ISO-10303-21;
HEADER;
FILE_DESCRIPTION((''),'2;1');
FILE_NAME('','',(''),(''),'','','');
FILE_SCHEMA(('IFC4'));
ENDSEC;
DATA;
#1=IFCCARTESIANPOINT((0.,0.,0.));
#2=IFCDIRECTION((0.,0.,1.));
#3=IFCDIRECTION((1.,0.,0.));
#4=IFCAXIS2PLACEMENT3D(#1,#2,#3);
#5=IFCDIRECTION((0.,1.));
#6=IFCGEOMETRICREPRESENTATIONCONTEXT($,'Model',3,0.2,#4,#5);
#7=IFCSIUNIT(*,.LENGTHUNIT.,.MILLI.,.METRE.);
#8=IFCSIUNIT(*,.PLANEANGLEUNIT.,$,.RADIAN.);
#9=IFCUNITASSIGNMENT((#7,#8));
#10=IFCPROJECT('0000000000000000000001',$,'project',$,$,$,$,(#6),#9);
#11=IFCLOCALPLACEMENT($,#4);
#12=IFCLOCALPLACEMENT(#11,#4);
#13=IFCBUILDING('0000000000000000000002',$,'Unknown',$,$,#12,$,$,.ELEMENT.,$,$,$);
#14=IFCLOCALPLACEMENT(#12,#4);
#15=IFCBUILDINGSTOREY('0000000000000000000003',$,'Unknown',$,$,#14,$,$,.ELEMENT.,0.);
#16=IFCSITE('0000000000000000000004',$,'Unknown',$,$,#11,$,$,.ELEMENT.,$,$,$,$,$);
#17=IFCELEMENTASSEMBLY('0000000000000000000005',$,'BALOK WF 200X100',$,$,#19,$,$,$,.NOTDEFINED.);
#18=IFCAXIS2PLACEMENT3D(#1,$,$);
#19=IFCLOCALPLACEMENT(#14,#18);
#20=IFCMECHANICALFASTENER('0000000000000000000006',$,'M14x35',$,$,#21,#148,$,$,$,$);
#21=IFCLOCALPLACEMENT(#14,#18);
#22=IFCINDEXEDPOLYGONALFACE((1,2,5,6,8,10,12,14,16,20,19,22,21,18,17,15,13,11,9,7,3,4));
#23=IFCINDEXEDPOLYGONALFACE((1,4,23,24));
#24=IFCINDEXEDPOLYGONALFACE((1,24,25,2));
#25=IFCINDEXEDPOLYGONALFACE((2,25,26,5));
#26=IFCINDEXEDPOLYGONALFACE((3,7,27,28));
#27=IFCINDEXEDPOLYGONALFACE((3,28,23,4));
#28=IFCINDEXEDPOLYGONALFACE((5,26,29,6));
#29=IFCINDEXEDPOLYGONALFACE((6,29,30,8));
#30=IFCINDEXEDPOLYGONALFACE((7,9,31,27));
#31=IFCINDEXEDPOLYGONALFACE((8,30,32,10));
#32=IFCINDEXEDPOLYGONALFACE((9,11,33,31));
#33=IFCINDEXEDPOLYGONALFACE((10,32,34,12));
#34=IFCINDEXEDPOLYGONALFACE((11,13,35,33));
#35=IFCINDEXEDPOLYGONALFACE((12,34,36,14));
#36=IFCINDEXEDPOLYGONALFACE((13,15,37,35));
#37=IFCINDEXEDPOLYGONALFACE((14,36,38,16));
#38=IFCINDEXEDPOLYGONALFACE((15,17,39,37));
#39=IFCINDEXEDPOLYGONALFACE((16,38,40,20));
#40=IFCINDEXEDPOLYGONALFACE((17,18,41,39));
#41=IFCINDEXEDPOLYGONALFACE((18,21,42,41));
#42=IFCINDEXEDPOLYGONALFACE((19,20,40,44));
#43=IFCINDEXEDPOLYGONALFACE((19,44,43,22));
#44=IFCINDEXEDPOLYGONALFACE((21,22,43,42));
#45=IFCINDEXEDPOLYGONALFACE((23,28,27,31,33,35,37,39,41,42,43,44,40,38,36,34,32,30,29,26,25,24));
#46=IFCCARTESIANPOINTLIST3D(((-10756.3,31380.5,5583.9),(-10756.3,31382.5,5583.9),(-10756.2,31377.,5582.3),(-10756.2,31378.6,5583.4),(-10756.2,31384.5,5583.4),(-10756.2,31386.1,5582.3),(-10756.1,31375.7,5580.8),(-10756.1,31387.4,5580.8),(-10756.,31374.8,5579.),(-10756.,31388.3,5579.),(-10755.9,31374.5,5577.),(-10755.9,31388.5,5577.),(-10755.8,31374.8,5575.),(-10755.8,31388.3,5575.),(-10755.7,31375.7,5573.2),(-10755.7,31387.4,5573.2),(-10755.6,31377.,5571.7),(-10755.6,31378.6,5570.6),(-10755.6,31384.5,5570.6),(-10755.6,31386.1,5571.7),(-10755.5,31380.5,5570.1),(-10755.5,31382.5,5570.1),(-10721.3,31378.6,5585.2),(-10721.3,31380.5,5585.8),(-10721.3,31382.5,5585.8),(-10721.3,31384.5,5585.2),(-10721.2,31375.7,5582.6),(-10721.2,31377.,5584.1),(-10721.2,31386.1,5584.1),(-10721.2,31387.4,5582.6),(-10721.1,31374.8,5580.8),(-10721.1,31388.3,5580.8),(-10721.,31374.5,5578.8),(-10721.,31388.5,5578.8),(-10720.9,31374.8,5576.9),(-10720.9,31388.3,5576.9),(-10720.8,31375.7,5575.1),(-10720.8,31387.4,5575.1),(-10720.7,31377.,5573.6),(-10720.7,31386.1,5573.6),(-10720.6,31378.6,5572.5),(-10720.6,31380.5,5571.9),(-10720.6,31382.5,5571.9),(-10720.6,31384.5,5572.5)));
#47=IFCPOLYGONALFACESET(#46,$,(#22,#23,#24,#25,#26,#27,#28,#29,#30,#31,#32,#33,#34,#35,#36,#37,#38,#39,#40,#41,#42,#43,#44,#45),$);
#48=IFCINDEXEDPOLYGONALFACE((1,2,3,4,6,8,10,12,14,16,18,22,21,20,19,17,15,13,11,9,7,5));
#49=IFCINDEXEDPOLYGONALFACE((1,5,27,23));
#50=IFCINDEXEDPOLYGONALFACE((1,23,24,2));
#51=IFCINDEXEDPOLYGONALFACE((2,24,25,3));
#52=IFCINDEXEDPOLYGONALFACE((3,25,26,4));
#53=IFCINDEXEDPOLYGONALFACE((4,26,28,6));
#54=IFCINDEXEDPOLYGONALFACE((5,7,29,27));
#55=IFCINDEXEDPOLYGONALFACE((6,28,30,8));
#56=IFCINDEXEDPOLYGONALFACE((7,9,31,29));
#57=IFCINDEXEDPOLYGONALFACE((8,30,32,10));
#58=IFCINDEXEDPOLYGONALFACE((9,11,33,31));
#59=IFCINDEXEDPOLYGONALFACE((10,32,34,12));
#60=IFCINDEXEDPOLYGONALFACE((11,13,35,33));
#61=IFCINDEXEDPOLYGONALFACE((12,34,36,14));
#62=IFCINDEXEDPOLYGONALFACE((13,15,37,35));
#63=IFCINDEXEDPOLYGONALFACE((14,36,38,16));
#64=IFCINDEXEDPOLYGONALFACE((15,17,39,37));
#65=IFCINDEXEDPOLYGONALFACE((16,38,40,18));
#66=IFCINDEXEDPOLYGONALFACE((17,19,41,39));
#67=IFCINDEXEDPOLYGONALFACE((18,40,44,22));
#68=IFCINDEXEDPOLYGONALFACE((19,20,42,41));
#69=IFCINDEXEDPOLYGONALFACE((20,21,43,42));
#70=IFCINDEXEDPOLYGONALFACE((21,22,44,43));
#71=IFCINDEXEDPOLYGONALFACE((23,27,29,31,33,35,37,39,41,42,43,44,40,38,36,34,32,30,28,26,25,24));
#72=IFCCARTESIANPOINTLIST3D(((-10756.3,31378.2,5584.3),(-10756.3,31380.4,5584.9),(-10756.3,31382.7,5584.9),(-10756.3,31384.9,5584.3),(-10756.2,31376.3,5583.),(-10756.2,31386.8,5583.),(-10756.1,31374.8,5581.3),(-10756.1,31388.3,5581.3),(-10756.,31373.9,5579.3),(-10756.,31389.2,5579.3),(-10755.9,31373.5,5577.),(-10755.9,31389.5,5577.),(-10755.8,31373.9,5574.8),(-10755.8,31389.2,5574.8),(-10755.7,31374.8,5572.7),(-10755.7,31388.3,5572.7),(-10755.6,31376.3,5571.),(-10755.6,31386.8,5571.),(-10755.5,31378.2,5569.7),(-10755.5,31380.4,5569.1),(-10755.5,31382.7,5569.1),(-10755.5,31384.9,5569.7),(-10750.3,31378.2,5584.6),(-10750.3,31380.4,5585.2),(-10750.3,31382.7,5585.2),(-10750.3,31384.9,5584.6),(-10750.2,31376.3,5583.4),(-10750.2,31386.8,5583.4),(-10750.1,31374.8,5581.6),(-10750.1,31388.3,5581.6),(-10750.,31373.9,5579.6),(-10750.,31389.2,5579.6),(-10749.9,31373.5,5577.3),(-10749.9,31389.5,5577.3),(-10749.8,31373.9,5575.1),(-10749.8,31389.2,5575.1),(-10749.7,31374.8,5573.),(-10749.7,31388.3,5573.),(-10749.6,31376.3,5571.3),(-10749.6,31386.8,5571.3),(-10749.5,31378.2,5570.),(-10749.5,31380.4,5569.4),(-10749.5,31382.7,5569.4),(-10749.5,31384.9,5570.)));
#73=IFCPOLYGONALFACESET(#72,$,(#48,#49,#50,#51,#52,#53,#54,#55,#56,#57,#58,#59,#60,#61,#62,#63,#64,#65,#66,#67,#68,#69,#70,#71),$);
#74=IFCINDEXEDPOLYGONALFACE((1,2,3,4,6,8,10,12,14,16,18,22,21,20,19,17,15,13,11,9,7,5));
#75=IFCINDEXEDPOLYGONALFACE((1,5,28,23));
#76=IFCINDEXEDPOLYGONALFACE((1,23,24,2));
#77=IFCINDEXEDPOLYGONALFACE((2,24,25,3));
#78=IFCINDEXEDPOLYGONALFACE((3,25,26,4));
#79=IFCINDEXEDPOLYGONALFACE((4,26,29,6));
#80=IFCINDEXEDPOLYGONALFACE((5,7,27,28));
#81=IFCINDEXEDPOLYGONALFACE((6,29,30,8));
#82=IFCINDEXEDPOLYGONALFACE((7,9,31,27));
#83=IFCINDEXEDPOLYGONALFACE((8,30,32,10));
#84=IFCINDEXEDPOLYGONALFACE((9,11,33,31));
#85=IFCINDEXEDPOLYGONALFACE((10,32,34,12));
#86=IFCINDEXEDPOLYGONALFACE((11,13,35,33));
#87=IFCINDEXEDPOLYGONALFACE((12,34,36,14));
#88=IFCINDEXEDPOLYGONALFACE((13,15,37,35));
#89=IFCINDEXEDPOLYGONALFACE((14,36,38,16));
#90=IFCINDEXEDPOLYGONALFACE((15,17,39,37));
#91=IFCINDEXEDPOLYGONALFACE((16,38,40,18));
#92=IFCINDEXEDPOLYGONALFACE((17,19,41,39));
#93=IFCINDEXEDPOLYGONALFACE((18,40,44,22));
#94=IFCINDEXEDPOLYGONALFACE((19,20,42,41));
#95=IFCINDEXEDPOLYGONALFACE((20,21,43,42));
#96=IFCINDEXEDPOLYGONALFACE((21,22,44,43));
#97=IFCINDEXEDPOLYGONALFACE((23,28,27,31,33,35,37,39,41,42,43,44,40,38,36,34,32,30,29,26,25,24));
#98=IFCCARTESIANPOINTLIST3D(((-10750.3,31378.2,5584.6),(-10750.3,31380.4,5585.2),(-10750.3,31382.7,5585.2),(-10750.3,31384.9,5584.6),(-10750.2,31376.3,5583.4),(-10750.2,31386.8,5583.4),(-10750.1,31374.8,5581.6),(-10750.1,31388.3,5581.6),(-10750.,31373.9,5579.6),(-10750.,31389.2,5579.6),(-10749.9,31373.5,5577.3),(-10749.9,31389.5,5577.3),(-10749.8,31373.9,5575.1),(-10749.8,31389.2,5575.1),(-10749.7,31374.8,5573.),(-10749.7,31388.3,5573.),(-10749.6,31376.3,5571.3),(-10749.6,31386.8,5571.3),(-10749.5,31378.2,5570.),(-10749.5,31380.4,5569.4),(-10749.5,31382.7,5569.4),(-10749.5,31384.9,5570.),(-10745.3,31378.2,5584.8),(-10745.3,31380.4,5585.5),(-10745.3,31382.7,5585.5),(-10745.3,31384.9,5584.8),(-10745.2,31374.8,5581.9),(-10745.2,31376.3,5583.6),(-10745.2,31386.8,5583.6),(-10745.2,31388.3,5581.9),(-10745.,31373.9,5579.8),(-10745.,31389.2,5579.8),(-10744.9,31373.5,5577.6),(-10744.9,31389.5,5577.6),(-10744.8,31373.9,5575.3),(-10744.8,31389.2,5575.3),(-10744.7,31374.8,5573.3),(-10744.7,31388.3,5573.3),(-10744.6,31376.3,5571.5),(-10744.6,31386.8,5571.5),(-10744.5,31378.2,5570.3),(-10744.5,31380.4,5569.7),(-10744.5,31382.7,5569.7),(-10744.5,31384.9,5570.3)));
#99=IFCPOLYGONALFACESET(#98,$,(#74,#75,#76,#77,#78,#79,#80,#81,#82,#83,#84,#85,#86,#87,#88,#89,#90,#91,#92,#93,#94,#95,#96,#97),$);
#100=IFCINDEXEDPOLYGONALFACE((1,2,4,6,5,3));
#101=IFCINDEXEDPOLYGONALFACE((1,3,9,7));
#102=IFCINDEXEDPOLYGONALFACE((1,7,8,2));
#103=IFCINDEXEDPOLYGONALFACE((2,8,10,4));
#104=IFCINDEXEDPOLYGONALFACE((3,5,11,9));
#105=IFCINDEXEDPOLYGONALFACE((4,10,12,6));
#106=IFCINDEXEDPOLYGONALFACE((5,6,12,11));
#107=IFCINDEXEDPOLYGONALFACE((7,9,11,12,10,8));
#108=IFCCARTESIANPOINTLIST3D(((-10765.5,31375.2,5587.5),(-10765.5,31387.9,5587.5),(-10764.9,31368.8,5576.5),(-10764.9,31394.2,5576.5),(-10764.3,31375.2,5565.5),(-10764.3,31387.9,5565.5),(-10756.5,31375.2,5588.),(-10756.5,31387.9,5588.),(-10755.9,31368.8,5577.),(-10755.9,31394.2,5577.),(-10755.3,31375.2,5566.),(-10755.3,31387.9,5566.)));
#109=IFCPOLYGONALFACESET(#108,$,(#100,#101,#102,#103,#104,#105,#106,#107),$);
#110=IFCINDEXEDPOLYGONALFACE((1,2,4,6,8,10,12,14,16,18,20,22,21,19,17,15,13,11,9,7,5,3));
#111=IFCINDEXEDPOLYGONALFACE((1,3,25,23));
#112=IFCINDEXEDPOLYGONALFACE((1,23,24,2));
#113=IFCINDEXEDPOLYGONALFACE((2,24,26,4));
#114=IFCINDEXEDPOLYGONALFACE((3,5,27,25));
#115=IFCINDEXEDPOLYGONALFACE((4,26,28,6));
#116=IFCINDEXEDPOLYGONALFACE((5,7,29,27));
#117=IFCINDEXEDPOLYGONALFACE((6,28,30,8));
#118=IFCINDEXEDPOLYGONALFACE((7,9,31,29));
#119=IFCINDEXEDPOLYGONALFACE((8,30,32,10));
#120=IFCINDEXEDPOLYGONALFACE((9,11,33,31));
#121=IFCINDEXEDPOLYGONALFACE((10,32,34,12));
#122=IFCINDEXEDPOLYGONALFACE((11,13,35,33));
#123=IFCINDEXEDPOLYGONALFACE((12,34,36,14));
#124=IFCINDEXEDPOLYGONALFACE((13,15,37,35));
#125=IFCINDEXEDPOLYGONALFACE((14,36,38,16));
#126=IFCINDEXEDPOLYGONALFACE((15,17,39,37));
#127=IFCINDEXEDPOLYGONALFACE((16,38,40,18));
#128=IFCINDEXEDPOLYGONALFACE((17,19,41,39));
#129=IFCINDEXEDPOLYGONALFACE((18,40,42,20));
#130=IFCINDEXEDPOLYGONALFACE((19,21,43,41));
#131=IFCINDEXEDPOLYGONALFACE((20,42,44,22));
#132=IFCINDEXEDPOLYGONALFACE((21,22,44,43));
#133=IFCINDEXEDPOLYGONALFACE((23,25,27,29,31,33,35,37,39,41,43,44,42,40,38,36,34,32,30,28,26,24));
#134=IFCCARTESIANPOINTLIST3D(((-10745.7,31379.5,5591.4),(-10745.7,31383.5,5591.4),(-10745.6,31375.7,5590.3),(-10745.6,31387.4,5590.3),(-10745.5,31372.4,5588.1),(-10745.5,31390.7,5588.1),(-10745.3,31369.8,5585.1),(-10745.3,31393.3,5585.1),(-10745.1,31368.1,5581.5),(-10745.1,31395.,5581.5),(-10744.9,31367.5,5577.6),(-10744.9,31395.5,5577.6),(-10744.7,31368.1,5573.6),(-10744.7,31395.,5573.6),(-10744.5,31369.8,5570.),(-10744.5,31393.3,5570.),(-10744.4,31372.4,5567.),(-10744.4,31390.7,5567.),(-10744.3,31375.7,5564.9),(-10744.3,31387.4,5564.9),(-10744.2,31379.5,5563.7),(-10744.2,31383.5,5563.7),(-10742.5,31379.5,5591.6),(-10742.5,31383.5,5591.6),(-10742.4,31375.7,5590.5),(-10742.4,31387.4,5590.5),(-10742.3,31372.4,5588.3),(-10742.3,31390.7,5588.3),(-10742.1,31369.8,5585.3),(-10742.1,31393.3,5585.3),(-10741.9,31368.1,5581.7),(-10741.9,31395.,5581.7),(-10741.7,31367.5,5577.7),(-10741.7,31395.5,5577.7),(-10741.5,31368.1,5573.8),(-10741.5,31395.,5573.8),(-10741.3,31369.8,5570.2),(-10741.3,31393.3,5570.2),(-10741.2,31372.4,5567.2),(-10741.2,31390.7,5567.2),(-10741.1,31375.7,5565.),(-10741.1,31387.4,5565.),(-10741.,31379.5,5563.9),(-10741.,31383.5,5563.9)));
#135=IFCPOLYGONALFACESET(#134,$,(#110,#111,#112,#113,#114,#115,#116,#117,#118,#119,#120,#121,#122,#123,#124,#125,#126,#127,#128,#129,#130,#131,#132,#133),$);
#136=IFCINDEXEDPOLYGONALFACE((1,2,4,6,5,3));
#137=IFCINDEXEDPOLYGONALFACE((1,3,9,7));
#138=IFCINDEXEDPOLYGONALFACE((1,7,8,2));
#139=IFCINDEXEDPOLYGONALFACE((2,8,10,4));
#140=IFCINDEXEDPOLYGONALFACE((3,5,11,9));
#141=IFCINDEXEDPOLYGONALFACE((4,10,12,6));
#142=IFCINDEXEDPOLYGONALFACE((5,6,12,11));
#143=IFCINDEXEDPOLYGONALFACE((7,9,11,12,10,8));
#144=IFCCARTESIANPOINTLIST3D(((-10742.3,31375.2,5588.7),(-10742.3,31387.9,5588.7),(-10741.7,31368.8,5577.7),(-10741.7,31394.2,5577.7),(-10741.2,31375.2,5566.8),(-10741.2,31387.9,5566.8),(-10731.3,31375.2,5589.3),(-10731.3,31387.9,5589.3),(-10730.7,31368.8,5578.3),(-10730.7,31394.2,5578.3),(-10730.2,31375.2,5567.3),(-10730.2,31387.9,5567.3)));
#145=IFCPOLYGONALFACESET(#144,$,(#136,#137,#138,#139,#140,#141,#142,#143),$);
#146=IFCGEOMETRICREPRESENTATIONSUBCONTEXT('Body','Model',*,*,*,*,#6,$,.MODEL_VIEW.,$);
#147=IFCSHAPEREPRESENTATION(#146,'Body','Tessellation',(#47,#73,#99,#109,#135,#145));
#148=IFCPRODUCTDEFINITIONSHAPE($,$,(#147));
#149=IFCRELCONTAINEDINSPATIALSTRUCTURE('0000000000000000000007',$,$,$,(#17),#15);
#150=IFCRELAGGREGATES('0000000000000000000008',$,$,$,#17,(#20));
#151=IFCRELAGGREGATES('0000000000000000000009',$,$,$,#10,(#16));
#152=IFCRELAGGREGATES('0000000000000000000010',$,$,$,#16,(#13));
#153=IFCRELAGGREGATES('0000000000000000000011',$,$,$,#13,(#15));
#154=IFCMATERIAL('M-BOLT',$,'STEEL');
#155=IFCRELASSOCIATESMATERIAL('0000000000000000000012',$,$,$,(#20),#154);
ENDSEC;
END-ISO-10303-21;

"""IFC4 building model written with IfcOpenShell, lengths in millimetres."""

from ifc_helpers import new_model, si_unit, direction, frame, origin_with_axes, place, context, subcontext, project, spatial, line, arc, indexed_curve, outline, extrude, source, transform, mapped, material, element, aggregate, save


model = new_model("IFC4")

# Units and contexts
model_context = context("Model", 3, precision=0.2, world=origin_with_axes(), true_north=direction((0.0, 1.0)))
body_context = subcontext(model_context, "Body", "Model", "MODEL_VIEW")
ifc_project = project(units=[si_unit("LENGTHUNIT", "METRE", prefix="MILLI"), si_unit("PLANEANGLEUNIT", "RADIAN")], contexts=[model_context])

# Site, building, storey
site_placement = place(None, origin_with_axes())
site = spatial("IfcSite", under=ifc_project, at=site_placement, Name="Unknown", CompositionType="ELEMENT")
building_placement = place(site_placement, origin_with_axes())
building = spatial("IfcBuilding", under=site, at=building_placement, Name="Unknown", CompositionType="ELEMENT")
storey_placement = place(building_placement, origin_with_axes())
storey = spatial("IfcBuildingStorey", under=building, at=storey_placement, Name="Unknown", CompositionType="ELEMENT", Elevation=0.0)

# Element assembly
assembly_1_placement = place(storey_placement, frame((-7044.1, 31466.5, 5721.5), z_axis=(0.0, 1.0, 0.0), x_axis=(-0.99863, 0.0, -0.052336)))
assembly_1 = element("IfcElementAssembly", 1, at=assembly_1_placement, inside=storey, Name="BALOK WF 200X100", PredefinedType="NOTDEFINED")

# Shared definitions
ifc_material_1 = material(Name="M-BOLT", Category="STEEL")

# Shared definitions
shared_shape_1 = source(origin_with_axes(), body_context, "Body", "SweptSolid", [
    extrude(outline(indexed_curve([(7.0, 0.0), (0.0, 7.0), (-7.0, 0.0), (0.0, -7.0)], segments=[arc(1, 2, 3), arc(3, 4, 1)])), frame((0.0, 0.0, 0.0), z_axis=(0.0, 0.0, -1.0), x_axis=(0.0, 1.0, 0.0)), (0.0, 0.0, 1.0), 35.0),
    extrude(outline(indexed_curve([(8.0, 0.0), (0.0, 8.0), (-8.0, 0.0), (0.0, -8.0)], segments=[arc(1, 2, 3), arc(3, 4, 1)])), frame((0.0, 0.0, 0.0), z_axis=(0.0, 0.0, -1.0), x_axis=(0.0, 1.0, 0.0)), (0.0, 0.0, 1.0), 6.0),
    extrude(outline(indexed_curve([(8.0, 0.0), (0.0, 8.0), (-8.0, 0.0), (0.0, -8.0)], segments=[arc(1, 2, 3), arc(3, 4, 1)])), frame((0.0, 0.0, -6.0), z_axis=(0.0, 0.0, -1.0), x_axis=(0.0, 1.0, 0.0)), (0.0, 0.0, 1.0), 5.0),
    extrude(outline(indexed_curve([(12.7, 0.0), (6.4, 11.0), (-6.4, 11.0), (-12.7, 0.0), (-6.4, -11.0), (6.4, -11.0)], segments=[line(1, 2, 3, 4, 5, 6, 1)])), frame((0.0, 0.0, 9.0), z_axis=(0.0, 0.0, -1.0), x_axis=(0.0, 1.0, 0.0)), (0.0, 0.0, 1.0), 9.0),
    extrude(outline(indexed_curve([(14.0, 0.0), (0.0, 14.0), (-14.0, 0.0), (0.0, -14.0)], segments=[arc(1, 2, 3), arc(3, 4, 1)])), frame((0.0, 0.0, -11.0), z_axis=(0.0, 0.0, -1.0), x_axis=(0.0, 1.0, 0.0)), (0.0, 0.0, 1.0), 3.2),
    extrude(outline(indexed_curve([(12.7, 0.0), (6.4, 11.0), (-6.4, 11.0), (-12.7, 0.0), (-6.4, -11.0), (6.4, -11.0)], segments=[line(1, 2, 3, 4, 5, 6, 1)])), frame((0.0, 0.0, -14.2), z_axis=(0.0, 0.0, -1.0), x_axis=(0.0, 1.0, 0.0)), (0.0, 0.0, 1.0), 11.0),
])

# Mechanical fastener
mechanical_fastener_1_placement = place(assembly_1_placement, frame((3714.2, 50.0, -85.0), z_axis=(1.0, 0.0, -0.000006), x_axis=(0.0, -1.0, 0.0)))
mechanical_fastener_1 = element("IfcMechanicalFastener", 2, at=mechanical_fastener_1_placement, material=ifc_material_1, Name="M14x35", context=body_context, shape_type="MappedRepresentation", body=[
    mapped(shared_shape_1, transform((0.0, 0.0, 0.0))),
])
aggregate(assembly_1, [mechanical_fastener_1])

save(model, "model.ifc")
